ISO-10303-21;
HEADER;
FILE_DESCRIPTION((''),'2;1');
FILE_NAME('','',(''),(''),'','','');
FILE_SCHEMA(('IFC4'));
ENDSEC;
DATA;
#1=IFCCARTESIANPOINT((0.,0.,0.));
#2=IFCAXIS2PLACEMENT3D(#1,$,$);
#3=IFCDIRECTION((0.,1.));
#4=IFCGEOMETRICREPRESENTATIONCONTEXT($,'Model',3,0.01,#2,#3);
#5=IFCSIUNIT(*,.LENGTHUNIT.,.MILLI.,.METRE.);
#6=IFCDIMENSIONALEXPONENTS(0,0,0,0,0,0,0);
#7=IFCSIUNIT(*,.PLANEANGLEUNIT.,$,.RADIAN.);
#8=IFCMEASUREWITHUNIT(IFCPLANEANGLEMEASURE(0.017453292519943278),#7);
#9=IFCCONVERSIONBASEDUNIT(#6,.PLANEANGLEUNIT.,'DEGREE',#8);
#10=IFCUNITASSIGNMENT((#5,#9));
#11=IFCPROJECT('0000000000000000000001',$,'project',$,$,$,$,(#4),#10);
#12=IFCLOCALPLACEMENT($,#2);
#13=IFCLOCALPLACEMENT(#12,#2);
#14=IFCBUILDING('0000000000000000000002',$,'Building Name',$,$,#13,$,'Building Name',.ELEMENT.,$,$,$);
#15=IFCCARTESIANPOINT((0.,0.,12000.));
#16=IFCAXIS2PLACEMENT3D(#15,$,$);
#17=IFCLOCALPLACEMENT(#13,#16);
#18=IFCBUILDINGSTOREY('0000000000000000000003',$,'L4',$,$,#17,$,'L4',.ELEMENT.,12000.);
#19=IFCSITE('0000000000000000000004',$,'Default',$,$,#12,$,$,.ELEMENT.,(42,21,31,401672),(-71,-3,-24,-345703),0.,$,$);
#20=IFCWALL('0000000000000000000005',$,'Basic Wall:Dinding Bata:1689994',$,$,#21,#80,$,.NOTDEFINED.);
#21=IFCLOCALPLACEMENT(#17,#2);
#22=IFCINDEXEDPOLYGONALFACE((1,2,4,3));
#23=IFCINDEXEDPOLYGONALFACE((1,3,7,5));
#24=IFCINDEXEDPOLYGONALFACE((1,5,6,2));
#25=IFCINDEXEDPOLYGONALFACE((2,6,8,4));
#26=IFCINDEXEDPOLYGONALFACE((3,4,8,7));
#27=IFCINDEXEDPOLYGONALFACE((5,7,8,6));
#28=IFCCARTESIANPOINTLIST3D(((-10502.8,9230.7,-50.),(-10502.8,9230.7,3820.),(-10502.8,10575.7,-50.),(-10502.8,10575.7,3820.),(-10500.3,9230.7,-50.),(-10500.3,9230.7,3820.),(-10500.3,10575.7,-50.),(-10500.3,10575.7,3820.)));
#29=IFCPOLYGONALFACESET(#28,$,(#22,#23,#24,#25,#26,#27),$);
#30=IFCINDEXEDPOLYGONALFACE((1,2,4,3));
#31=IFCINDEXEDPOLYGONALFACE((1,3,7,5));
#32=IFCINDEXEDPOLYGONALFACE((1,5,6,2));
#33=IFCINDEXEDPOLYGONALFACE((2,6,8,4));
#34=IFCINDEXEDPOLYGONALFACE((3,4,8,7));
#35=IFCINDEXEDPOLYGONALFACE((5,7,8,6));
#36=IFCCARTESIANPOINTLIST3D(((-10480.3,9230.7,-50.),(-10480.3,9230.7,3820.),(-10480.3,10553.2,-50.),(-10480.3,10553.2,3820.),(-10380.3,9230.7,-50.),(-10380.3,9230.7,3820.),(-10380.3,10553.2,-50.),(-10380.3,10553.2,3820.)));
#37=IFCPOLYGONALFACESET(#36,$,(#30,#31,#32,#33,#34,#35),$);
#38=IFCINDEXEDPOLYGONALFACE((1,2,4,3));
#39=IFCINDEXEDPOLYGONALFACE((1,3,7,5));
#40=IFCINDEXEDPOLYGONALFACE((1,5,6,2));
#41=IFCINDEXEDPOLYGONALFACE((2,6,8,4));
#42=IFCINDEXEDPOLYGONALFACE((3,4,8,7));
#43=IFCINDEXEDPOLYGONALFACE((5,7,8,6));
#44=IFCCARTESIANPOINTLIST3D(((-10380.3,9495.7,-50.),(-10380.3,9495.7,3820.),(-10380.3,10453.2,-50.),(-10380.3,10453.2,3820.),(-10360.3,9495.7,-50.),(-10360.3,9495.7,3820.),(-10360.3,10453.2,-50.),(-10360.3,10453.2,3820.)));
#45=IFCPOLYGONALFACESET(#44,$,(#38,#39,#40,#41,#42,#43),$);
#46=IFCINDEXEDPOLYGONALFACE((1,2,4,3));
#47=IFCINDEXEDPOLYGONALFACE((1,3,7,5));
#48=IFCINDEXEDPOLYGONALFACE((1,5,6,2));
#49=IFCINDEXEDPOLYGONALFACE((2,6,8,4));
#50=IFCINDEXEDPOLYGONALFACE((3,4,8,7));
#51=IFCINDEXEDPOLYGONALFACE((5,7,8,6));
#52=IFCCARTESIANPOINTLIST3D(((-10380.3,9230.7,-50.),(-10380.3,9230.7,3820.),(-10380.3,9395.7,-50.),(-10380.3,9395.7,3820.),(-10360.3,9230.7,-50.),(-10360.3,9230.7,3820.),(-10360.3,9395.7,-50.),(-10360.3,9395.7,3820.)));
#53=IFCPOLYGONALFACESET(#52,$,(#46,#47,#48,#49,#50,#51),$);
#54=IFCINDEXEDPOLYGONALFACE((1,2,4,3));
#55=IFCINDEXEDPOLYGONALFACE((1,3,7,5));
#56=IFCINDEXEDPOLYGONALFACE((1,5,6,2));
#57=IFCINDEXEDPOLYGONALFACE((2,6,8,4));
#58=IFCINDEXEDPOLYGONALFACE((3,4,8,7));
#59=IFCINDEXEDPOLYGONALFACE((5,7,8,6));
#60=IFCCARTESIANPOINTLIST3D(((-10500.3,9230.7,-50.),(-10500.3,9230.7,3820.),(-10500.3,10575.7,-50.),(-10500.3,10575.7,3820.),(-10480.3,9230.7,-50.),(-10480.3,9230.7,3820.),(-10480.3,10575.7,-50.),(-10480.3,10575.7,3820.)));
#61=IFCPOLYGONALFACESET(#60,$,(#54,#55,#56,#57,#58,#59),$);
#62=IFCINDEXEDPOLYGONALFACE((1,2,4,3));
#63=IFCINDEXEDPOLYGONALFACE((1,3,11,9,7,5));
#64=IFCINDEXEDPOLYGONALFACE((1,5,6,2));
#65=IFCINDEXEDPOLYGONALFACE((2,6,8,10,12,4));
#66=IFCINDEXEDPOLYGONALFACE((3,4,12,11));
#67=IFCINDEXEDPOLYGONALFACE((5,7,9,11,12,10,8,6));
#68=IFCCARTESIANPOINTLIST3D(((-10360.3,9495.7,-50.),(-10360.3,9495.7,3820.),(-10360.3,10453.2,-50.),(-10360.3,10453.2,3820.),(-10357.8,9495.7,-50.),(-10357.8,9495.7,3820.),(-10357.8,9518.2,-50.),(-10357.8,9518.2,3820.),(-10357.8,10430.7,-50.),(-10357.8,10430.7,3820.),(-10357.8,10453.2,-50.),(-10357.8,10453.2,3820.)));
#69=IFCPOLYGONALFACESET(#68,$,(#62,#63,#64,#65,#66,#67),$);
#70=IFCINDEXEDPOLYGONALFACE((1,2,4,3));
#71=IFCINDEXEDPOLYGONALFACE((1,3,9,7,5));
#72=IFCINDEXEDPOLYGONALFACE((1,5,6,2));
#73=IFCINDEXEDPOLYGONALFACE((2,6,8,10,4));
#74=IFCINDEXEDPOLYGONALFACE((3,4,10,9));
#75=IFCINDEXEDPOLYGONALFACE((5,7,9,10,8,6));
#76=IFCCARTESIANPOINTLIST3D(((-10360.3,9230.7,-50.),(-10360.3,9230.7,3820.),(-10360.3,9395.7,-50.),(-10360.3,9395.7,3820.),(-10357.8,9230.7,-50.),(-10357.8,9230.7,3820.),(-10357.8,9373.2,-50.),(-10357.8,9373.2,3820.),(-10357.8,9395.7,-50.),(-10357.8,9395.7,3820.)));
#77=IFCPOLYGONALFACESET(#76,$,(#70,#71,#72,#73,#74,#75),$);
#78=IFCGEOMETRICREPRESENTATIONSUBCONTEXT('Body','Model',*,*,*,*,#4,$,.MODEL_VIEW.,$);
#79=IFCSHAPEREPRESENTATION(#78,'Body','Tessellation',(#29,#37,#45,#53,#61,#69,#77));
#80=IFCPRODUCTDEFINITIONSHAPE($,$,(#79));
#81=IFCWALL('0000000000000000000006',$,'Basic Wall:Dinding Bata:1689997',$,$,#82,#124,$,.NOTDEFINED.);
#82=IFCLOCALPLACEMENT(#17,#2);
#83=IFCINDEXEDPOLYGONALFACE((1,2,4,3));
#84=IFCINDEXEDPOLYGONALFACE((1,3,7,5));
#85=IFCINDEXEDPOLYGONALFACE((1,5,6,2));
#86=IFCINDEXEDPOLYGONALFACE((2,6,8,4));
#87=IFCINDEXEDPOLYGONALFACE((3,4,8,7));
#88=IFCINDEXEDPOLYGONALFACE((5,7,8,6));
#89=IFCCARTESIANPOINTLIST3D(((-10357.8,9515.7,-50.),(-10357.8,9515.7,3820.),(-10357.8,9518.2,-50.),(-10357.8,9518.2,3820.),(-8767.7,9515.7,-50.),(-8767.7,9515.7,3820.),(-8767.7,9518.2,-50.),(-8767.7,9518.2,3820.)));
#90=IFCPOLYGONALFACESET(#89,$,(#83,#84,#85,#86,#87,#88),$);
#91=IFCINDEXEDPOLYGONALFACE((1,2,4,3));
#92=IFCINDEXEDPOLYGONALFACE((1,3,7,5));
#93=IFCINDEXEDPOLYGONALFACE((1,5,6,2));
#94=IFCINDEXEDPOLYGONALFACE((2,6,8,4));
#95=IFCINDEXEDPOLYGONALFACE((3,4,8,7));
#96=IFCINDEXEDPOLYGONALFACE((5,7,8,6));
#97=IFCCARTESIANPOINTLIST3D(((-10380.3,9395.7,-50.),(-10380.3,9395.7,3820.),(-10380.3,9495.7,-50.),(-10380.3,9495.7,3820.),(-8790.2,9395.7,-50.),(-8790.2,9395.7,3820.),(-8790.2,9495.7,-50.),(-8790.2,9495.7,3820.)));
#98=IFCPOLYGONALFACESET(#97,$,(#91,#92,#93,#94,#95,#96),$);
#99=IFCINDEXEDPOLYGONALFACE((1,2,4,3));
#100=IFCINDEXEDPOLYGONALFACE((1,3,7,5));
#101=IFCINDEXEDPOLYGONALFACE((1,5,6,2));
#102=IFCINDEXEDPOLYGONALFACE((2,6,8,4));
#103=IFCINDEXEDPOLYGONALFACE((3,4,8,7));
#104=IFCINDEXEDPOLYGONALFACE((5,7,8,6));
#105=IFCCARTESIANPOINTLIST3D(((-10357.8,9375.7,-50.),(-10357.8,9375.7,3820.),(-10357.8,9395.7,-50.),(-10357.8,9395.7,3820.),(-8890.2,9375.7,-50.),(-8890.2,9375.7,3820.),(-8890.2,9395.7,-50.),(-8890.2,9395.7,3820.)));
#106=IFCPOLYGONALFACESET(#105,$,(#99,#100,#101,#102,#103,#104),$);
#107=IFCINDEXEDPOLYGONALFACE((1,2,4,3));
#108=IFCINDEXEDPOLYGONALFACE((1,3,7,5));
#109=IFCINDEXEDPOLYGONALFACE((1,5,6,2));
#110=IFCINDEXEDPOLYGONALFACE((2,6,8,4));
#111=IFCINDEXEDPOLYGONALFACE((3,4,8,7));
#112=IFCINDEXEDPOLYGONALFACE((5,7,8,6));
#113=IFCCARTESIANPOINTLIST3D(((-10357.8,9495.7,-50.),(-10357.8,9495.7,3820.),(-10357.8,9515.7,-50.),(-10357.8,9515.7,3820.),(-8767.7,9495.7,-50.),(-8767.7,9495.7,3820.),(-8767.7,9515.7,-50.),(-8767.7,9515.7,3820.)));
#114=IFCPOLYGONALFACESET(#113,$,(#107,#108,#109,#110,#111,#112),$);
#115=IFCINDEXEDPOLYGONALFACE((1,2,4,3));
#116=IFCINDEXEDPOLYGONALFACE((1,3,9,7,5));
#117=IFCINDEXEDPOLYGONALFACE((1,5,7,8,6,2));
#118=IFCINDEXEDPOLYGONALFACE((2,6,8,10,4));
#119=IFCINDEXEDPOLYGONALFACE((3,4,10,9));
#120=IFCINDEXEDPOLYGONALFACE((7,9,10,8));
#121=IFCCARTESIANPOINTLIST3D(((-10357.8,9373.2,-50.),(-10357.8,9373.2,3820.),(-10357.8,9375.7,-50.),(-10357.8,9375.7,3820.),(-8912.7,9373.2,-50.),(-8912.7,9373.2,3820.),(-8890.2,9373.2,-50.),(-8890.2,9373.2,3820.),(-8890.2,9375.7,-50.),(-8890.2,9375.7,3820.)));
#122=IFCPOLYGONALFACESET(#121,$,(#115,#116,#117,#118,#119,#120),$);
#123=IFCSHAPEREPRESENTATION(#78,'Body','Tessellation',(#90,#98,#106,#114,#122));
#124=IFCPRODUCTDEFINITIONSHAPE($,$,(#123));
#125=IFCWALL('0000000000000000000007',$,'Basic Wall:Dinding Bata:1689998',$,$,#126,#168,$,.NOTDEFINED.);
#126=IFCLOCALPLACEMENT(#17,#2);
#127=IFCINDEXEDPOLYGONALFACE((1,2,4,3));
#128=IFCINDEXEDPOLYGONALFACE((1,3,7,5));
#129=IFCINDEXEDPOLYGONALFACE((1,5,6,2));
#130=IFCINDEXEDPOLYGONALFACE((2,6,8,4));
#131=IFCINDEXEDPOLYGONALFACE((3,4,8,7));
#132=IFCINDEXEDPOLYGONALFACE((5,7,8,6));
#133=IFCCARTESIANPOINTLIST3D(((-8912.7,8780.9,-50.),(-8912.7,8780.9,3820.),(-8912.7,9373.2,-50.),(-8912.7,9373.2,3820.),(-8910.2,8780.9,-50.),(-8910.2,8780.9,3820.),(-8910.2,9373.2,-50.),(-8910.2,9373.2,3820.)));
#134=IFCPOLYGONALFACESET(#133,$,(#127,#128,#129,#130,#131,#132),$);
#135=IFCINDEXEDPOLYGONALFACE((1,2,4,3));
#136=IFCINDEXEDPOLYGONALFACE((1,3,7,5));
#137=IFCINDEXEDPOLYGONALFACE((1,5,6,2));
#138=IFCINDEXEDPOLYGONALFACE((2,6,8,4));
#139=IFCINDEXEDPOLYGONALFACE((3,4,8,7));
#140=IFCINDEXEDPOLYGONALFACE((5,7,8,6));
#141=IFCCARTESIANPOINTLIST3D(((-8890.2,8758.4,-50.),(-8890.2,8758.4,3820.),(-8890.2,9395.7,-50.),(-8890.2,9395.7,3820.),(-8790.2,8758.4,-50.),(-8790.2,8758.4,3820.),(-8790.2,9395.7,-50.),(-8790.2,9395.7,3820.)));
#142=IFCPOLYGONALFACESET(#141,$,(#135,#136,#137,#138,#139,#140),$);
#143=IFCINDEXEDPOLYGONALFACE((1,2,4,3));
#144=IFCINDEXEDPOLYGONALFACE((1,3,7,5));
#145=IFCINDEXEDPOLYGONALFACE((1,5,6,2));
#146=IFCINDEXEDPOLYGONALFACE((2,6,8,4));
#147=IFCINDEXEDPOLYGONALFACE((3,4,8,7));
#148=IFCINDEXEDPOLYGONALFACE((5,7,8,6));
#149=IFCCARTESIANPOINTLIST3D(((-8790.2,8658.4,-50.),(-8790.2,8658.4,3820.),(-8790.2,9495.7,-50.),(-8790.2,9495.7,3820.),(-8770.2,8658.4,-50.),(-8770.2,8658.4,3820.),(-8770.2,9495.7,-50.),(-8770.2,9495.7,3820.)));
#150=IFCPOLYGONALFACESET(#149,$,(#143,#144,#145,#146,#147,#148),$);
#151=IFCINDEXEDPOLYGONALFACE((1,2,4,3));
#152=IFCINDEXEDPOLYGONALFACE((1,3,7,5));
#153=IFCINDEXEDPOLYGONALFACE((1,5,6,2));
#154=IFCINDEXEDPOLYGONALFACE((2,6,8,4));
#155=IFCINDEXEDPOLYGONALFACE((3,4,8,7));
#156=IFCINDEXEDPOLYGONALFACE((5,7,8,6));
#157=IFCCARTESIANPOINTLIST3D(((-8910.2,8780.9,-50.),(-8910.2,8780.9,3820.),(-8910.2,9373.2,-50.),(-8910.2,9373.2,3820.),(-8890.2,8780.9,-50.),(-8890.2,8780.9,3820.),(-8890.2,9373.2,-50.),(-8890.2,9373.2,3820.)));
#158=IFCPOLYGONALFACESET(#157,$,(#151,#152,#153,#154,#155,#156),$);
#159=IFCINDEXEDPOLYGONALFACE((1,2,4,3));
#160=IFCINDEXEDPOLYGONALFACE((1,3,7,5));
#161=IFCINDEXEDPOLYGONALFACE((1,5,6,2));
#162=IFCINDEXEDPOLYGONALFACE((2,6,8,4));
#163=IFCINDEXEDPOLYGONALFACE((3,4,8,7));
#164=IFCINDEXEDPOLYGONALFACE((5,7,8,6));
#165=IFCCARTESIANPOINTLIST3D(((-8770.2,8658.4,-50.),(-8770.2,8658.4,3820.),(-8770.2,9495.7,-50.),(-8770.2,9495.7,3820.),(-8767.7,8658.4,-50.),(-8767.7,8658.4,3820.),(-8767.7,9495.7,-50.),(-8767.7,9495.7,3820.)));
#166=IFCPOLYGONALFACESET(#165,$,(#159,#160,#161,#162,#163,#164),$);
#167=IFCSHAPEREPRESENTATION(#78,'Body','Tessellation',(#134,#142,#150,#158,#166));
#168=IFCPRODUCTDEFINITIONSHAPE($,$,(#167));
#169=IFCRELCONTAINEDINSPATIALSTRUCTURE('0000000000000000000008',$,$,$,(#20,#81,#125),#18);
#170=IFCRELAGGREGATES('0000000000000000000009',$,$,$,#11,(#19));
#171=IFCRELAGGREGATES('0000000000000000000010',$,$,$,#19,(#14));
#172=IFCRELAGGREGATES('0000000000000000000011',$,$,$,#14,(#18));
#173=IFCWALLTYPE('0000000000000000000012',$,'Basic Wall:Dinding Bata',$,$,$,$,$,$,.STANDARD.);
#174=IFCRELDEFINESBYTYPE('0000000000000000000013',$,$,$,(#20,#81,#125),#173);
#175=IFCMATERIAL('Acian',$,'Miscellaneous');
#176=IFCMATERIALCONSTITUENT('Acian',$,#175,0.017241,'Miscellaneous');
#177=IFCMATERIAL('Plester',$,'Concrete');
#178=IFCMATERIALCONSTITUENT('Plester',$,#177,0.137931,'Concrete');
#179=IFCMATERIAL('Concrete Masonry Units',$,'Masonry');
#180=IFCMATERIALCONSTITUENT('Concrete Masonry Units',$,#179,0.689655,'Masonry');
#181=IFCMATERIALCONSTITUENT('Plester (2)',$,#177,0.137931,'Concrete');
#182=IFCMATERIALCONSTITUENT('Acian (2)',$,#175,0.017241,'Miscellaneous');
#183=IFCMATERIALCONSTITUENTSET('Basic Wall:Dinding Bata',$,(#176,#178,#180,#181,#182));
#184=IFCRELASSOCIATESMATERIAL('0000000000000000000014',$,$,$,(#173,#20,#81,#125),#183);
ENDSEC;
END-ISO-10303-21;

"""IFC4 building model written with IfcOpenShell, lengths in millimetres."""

from ifc_helpers import new_model, entity, si_unit, converted_unit, direction, frame, origin, place, context, subcontext, project, spatial, indexed_curve, outline, extrude, material, constituent, constituent_set, type_object, element, save


model = new_model("IFC4")

# Units and contexts
model_context = context("Model", 3, precision=0.01, world=origin(), true_north=direction((0.0, 1.0)))
body_context = subcontext(model_context, "Body", "Model", "MODEL_VIEW")
ifc_project = project(units=[si_unit("LENGTHUNIT", "METRE", prefix="MILLI"), converted_unit("PLANEANGLEUNIT", "DEGREE", entity("IfcPlaneAngleMeasure", 0.017453292519943278), si_unit("PLANEANGLEUNIT", "RADIAN"), dimensions=[0, 0, 0, 0, 0, 0, 0])], contexts=[model_context])

# Site, building, storey
site_placement = place(None, origin())
site = spatial("IfcSite", under=ifc_project, at=site_placement, Name="Default", CompositionType="ELEMENT", RefLatitude=(42, 21, 31, 401672), RefLongitude=(-71, -3, -24, -345703), RefElevation=0.0)
building_placement = place(site_placement, origin())
building = spatial("IfcBuilding", under=site, at=building_placement, Name="Building Name", LongName="Building Name", CompositionType="ELEMENT")
storey_placement = place(building_placement, frame((0.0, 0.0, 12000.0)))
storey = spatial("IfcBuildingStorey", under=building, at=storey_placement, Name="L4", LongName="L4", CompositionType="ELEMENT", Elevation=12000.0)

# Walls
ifc_material_1 = material(Name="Acian", Category="Miscellaneous")
ifc_constituent_1 = constituent(ifc_material_1, Name="Acian", Category="Miscellaneous", fraction=0.017241)
ifc_material_2 = material(Name="Plester", Category="Concrete")
ifc_constituent_2 = constituent(ifc_material_2, Name="Plester", Category="Concrete", fraction=0.137931)
ifc_material_3 = material(Name="Concrete Masonry Units", Category="Masonry")
ifc_constituent_3 = constituent(ifc_material_3, Name="Concrete Masonry Units", Category="Masonry", fraction=0.689655)
ifc_constituent_4 = constituent(ifc_material_2, Name="Plester (2)", Category="Concrete", fraction=0.137931)
ifc_constituent_5 = constituent(ifc_material_1, Name="Acian (2)", Category="Miscellaneous", fraction=0.017241)
ifc_constituent_set = constituent_set(constituents=[ifc_constituent_1, ifc_constituent_2, ifc_constituent_3, ifc_constituent_4, ifc_constituent_5], Name="Basic Wall:Dinding Bata")
wall_type = type_object("IfcWallType", Name="Basic Wall:Dinding Bata", PredefinedType="STANDARD", material=ifc_constituent_set)
wall_1_placement = place(storey_placement, frame((-10430.3, 9230.7, -50.0), z_axis=(0.0, 0.0, 1.0), x_axis=(0.0, 1.0, 0.0)))
element("IfcWall", 1, at=wall_1_placement, inside=storey, type_object=wall_type, material=ifc_constituent_set, Name="Basic Wall:Dinding Bata:1689994", PredefinedType="NOTDEFINED", context=body_context, shape_type="SweptSolid", body=[
    extrude(outline(indexed_curve([(-1.3, -672.5), (1.2, -672.5), (1.3, 672.5), (-1.2, 672.5), (-1.3, -672.5)], self_intersect=False)), frame((672.5, 71.3, 0.0), z_axis=(0.0, 0.0, 1.0), x_axis=(0.0, -1.0, 0.0)), (0.0, 0.0, 1.0), 3870.0),
    extrude(outline(indexed_curve([(-661.3, -50.0), (661.3, -50.0), (661.3, 50.0), (-661.3, 50.0), (-661.3, -50.0)], self_intersect=False)), frame((661.3, 0.0, 0.0)), (0.0, 0.0, 1.0), 3870.0),
    extrude(outline(indexed_curve([(-478.8, -10.0), (478.8, -10.0), (478.8, 10.0), (-478.8, 10.0), (-478.8, -10.0)], self_intersect=False)), frame((743.8, -60.0, 0.0), z_axis=(0.0, 0.0, 1.0), x_axis=(-1.0, 0.0, 0.0)), (0.0, 0.0, 1.0), 3870.0),
    extrude(outline(indexed_curve([(-82.5, -10.0), (82.5, -10.0), (82.5, 10.0), (-82.5, 10.0), (-82.5, -10.0)], self_intersect=False)), frame((82.5, -60.0, 0.0)), (0.0, 0.0, 1.0), 3870.0),
    extrude(outline(indexed_curve([(-672.5, -10.0), (672.5, -10.0), (672.5, 10.0), (-672.5, 10.0), (-672.5, -10.0)], self_intersect=False)), frame((672.5, 60.0, 0.0)), (0.0, 0.0, 1.0), 3870.0),
    extrude(outline(indexed_curve([(456.3, -0.8), (478.8, -0.8), (478.8, 1.7), (-478.8, 1.7), (-478.8, -0.8), (-456.3, -0.8), (456.3, -0.8)], self_intersect=False)), frame((743.8, -71.7, 0.0)), (0.0, 0.0, 1.0), 3870.0),
    extrude(outline(indexed_curve([(48.0, -1.0), (70.5, -1.0), (70.5, 1.5), (-94.5, 1.5), (-94.5, -1.0), (48.0, -1.0)], self_intersect=False)), frame((94.5, -71.5, 0.0)), (0.0, 0.0, 1.0), 3870.0),
])
wall_2_placement = place(storey_placement, frame((-10357.8, 9445.7, -50.0)))
element("IfcWall", 2, at=wall_2_placement, inside=storey, type_object=wall_type, material=ifc_constituent_set, Name="Basic Wall:Dinding Bata:1689997", PredefinedType="NOTDEFINED", context=body_context, shape_type="SweptSolid", body=[
    extrude(outline(indexed_curve([(-1.3, -795.0), (1.2, -795.0), (1.3, 795.0), (-1.2, 795.0), (-1.3, -795.0)], self_intersect=False)), frame((795.0, 71.3, 0.0), z_axis=(0.0, 0.0, 1.0), x_axis=(0.0, -1.0, 0.0)), (0.0, 0.0, 1.0), 3870.0),
    extrude(outline(indexed_curve([(-795.0, -50.0), (795.0, -50.0), (795.0, 50.0), (-795.0, 50.0), (-795.0, -50.0)], self_intersect=False)), frame((772.5, 0.0, 0.0)), (0.0, 0.0, 1.0), 3870.0),
    extrude(outline(indexed_curve([(-733.8, -10.0), (733.8, -10.0), (733.8, 10.0), (-733.8, 10.0), (-733.8, -10.0)], self_intersect=False)), frame((733.8, -60.0, 0.0)), (0.0, 0.0, 1.0), 3870.0),
    extrude(outline(indexed_curve([(-795.0, -10.0), (795.0, -10.0), (795.0, 10.0), (-795.0, 10.0), (-795.0, -10.0)], self_intersect=False)), frame((795.0, 60.0, 0.0)), (0.0, 0.0, 1.0), 3870.0),
    extrude(outline(indexed_curve([(569.0, -1.0), (591.5, -1.0), (591.5, 1.5), (-876.0, 1.5), (-876.0, -1.0), (569.0, -1.0)], self_intersect=False)), frame((876.0, -71.5, 0.0)), (0.0, 0.0, 1.0), 3870.0),
])
wall_3_placement = place(storey_placement, frame((-8840.2, 8780.9, -50.0), z_axis=(0.0, 0.0, 1.0), x_axis=(0.0, 1.0, 0.0)))
element("IfcWall", 3, at=wall_3_placement, inside=storey, type_object=wall_type, material=ifc_constituent_set, Name="Basic Wall:Dinding Bata:1689998", PredefinedType="NOTDEFINED", context=body_context, shape_type="SweptSolid", body=[
    extrude(outline(indexed_curve([(-1.2, -296.2), (1.2, -296.2), (1.3, 296.2), (-1.2, 296.2), (-1.2, -296.2)], self_intersect=False)), frame((296.2, 71.3, 0.0), z_axis=(0.0, 0.0, 1.0), x_axis=(0.0, -1.0, 0.0)), (0.0, 0.0, 1.0), 3870.0),
    extrude(outline(indexed_curve([(-318.7, -50.0), (318.7, -50.0), (318.7, 50.0), (-318.7, 50.0), (-318.7, -50.0)], self_intersect=False)), frame((296.2, 0.0, 0.0)), (0.0, 0.0, 1.0), 3870.0),
    extrude(outline(indexed_curve([(-418.7, -10.0), (418.7, -10.0), (418.7, 10.0), (-418.7, 10.0), (-418.7, -10.0)], self_intersect=False)), frame((296.2, -60.0, 0.0)), (0.0, 0.0, 1.0), 3870.0),
    extrude(outline(indexed_curve([(-296.2, -10.0), (296.2, -10.0), (296.2, 10.0), (-296.2, 10.0), (-296.2, -10.0)], self_intersect=False)), frame((296.2, 60.0, 0.0)), (0.0, 0.0, 1.0), 3870.0),
    extrude(outline(indexed_curve([(-1.3, -418.7), (1.2, -418.7), (1.2, 418.7), (-1.2, 418.7), (-1.3, -418.7)], self_intersect=False)), frame((296.2, -71.2, 0.0), z_axis=(0.0, 0.0, 1.0), x_axis=(0.0, 1.0, 0.0)), (0.0, 0.0, 1.0), 3870.0),
])

save(model, "model.ifc")
